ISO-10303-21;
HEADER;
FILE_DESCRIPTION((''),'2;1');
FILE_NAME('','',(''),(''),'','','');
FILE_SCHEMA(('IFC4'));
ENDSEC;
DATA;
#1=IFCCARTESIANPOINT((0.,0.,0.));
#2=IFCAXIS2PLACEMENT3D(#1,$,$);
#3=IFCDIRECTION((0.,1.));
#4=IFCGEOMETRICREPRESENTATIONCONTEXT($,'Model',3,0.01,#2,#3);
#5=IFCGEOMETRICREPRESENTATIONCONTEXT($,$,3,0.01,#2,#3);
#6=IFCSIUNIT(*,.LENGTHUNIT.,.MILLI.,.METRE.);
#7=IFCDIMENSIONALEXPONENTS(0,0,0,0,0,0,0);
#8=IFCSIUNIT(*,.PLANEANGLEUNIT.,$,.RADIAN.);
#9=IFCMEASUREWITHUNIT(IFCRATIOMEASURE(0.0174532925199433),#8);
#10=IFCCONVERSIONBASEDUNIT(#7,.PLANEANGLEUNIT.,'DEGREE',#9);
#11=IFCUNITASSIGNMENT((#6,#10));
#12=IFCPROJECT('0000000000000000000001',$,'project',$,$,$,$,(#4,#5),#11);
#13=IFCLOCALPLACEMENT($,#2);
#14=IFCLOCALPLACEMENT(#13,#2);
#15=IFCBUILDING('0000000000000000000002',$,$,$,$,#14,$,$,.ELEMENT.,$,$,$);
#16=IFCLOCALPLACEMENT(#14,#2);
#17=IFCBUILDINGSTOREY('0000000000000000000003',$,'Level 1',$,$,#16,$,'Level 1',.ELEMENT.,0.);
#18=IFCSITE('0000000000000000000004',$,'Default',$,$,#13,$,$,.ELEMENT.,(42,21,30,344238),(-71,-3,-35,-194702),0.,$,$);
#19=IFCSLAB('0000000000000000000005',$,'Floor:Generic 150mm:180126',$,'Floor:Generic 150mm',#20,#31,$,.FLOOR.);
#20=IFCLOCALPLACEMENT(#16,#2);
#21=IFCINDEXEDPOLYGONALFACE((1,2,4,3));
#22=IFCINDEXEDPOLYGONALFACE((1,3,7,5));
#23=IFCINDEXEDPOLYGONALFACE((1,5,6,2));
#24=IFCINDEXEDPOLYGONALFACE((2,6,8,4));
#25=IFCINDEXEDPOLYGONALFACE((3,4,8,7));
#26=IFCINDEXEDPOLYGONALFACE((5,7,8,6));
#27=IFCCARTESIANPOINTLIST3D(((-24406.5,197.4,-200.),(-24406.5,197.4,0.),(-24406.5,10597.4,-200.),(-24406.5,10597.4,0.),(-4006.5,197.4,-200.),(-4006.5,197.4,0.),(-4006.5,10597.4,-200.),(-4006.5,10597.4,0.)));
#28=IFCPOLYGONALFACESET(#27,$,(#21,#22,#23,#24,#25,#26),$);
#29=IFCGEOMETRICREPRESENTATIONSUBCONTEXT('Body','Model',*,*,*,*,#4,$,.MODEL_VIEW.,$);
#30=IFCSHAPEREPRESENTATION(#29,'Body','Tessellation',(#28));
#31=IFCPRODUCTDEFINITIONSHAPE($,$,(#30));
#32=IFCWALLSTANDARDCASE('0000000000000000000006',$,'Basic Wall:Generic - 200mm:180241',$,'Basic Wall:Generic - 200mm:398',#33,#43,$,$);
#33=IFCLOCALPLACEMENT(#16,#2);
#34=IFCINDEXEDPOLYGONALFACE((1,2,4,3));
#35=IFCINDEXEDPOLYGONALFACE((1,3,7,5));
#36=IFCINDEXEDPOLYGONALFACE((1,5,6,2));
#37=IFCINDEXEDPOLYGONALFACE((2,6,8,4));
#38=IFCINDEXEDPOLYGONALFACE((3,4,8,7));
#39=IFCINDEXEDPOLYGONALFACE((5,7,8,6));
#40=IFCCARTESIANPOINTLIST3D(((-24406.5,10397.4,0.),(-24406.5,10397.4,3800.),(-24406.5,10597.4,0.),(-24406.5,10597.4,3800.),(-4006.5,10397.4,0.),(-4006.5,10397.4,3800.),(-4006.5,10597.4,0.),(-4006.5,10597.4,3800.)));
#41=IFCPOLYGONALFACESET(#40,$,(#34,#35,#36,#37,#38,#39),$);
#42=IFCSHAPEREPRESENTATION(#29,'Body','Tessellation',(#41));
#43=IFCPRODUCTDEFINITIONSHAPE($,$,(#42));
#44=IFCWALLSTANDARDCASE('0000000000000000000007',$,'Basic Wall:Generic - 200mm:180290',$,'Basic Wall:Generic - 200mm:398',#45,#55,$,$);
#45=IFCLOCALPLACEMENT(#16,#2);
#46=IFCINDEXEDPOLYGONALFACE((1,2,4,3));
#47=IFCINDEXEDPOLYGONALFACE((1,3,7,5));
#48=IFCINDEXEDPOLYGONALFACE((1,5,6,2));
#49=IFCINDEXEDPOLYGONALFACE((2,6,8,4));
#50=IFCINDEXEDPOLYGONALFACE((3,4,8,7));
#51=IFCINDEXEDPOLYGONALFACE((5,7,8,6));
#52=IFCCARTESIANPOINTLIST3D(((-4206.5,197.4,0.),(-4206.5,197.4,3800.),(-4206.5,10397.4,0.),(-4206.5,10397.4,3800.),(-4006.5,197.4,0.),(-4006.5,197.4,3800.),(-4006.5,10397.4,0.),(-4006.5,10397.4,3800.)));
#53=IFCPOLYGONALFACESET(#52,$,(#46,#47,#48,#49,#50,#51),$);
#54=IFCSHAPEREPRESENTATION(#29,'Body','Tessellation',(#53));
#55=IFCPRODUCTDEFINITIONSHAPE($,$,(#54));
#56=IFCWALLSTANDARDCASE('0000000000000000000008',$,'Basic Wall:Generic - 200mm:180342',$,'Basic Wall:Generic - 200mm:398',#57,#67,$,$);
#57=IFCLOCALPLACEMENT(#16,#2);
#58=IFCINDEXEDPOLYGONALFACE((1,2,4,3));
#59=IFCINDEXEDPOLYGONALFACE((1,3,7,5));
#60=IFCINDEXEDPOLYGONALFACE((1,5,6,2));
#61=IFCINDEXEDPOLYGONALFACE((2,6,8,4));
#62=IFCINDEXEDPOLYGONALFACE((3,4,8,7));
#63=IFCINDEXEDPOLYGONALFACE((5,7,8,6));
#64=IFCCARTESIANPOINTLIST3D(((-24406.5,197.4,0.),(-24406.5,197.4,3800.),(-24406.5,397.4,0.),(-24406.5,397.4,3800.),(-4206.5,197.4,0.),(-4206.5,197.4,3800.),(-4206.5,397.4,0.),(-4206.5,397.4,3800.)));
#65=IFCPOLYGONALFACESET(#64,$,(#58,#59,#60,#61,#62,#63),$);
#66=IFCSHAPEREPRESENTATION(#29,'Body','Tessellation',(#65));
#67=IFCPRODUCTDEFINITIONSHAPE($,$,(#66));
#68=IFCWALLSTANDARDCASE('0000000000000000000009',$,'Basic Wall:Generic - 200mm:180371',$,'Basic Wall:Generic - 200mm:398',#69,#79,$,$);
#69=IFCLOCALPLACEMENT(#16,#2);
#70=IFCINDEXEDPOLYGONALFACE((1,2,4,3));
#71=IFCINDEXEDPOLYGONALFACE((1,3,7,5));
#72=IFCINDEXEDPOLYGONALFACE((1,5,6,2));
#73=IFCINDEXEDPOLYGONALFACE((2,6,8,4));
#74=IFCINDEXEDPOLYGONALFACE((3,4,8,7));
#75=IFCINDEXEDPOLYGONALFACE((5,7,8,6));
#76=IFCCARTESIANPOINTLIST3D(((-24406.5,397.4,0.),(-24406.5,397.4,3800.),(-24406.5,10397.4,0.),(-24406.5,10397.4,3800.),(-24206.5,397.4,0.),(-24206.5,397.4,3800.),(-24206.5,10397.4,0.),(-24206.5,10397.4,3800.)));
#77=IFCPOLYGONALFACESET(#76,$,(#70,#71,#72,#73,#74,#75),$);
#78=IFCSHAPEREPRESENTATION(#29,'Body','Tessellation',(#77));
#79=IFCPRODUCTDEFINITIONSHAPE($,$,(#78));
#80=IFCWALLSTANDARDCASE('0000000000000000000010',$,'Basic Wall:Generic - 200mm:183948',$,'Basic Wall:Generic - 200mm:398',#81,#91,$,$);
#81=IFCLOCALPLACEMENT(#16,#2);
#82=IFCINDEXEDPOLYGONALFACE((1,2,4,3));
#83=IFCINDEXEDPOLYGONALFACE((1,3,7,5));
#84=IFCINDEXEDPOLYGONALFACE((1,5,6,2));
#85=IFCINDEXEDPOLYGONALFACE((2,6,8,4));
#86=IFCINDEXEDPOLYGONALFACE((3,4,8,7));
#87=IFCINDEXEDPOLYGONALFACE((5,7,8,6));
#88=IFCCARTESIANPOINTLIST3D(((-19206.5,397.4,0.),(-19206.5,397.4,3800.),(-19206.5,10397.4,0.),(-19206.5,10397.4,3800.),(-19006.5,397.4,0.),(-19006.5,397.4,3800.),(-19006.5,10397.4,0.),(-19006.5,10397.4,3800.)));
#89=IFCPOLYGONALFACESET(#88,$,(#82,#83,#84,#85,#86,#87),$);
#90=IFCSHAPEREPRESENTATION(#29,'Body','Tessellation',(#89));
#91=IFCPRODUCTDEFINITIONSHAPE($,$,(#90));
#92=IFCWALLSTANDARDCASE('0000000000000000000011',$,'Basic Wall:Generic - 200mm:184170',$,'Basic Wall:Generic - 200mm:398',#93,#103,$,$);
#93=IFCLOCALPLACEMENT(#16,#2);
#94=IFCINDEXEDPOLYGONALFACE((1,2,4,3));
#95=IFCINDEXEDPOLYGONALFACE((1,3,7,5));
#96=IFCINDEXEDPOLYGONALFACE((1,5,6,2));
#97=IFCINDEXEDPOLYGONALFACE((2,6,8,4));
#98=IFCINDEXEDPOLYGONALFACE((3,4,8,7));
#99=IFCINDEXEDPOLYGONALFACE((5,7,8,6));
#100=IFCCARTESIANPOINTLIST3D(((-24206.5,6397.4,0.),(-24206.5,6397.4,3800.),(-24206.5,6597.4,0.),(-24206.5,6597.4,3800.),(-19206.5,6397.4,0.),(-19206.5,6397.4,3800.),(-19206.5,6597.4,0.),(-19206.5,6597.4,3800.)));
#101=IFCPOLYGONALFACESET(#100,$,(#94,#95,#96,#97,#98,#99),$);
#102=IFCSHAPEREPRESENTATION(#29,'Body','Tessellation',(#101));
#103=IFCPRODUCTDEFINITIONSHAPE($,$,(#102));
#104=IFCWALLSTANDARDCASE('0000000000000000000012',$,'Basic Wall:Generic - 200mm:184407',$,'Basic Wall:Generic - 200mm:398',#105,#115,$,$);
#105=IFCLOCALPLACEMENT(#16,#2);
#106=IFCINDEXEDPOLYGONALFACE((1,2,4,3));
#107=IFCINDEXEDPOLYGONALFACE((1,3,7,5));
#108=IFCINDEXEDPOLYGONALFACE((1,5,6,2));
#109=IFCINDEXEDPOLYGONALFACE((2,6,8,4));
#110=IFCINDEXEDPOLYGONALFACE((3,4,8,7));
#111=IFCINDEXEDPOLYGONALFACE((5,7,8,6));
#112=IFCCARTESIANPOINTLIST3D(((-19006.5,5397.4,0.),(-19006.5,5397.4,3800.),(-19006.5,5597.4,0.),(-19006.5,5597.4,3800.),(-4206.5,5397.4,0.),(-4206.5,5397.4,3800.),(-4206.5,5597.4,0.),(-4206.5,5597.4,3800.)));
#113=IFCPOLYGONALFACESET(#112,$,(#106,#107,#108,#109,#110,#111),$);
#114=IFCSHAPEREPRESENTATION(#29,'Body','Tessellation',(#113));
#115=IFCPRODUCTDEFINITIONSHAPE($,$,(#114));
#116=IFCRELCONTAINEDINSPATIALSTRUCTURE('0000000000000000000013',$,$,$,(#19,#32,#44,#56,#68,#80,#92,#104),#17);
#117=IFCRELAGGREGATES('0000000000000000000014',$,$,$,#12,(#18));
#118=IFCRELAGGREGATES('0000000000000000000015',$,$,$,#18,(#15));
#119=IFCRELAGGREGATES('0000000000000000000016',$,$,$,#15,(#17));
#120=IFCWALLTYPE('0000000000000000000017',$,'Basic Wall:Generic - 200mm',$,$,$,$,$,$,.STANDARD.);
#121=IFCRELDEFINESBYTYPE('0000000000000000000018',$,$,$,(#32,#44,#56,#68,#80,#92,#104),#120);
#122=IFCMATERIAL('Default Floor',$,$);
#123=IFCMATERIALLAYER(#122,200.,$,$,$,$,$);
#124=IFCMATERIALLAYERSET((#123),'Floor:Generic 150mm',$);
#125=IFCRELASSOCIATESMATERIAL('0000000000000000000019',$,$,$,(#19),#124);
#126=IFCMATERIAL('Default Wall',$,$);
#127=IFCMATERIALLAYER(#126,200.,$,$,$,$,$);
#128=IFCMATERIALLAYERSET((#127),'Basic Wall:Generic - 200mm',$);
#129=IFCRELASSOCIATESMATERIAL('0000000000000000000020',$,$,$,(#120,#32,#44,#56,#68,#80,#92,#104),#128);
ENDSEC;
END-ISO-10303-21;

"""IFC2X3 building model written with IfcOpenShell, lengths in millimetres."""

from ifc_helpers import new_model, entity, si_unit, converted_unit, direction, frame, frame_2d, origin, origin_2d_with_axis, place, context, subcontext, project, spatial, rectangle, extrude, material, layer, layer_set, layer_usage, type_object, element, save


model = new_model("IFC2X3")

# Units and contexts
model_context = context("Model", 3, precision=0.01, world=origin(), true_north=direction((0.0, 1.0)))
context_of_model = context(None, 3, precision=0.01, world=origin(), true_north=direction((0.0, 1.0)))
body_context = subcontext(model_context, "Body", "Model", "MODEL_VIEW")
ifc_project = project(units=[si_unit("LENGTHUNIT", "METRE", prefix="MILLI"), converted_unit("PLANEANGLEUNIT", "DEGREE", entity("IfcRatioMeasure", 0.0174532925199433), si_unit("PLANEANGLEUNIT", "RADIAN"), dimensions=[0, 0, 0, 0, 0, 0, 0])], contexts=[model_context, context_of_model])

# Site, building, storey
site_placement = place(None, origin())
site = spatial("IfcSite", under=ifc_project, at=site_placement, Name="Default", CompositionType="ELEMENT", RefLatitude=(42, 21, 30, 344238), RefLongitude=(-71, -3, -35, -194702), RefElevation=0.0)
building_placement = place(site_placement, origin())
building = spatial("IfcBuilding", under=site, at=building_placement, CompositionType="ELEMENT")
storey_placement = place(building_placement, origin())
storey = spatial("IfcBuildingStorey", under=building, at=storey_placement, Name="Level 1", LongName="Level 1", CompositionType="ELEMENT", Elevation=0.0)

# Slab
ifc_material_1 = material(Name="Default Floor")
ifc_layer_1 = layer(ifc_material_1, 200.0)
ifc_layer_set_1 = layer_set([ifc_layer_1], Name="Floor:Generic 150mm")
ifc_layer_usage_1 = layer_usage(ifc_layer_set_1, "AXIS3", "POSITIVE", 0.0)
slab_placement = place(storey_placement, origin())
element("IfcSlab", 1, at=slab_placement, inside=storey, material=ifc_layer_usage_1, Name="Floor:Generic 150mm:180126", ObjectType="Floor:Generic 150mm", PredefinedType="FLOOR", context=body_context, shape_type="SweptSolid", body=[
    extrude(rectangle(XDim=10400.0, YDim=20400.0, at=origin_2d_with_axis()), frame((-14206.5, 5397.4, 0.0), z_axis=(0.0, 0.0, -1.0), x_axis=(0.0, 1.0, 0.0)), (0.0, 0.0, 1.0), 200.0),
])

# Walls
ifc_material_2 = material(Name="Default Wall")
ifc_layer_2 = layer(ifc_material_2, 200.0)
ifc_layer_set_2 = layer_set([ifc_layer_2], Name="Basic Wall:Generic - 200mm")
ifc_layer_usage_2 = layer_usage(ifc_layer_set_2, "AXIS2", "NEGATIVE", 100.0)
wall_type = type_object("IfcWallType", Name="Basic Wall:Generic - 200mm", PredefinedType="STANDARD", material=ifc_layer_set_2)
wall_1_placement = place(storey_placement, frame((-24406.5, 10497.4, 0.0)))
element("IfcWallStandardCase", 2, at=wall_1_placement, inside=storey, type_object=wall_type, material=ifc_layer_usage_2, Name="Basic Wall:Generic - 200mm:180241", ObjectType="Basic Wall:Generic - 200mm:398", context=body_context, shape_type="SweptSolid", body=[
    extrude(rectangle(XDim=20400.0, YDim=200.0, at=frame_2d((10200.0, 0.0), x_axis=(-1.0, 0.0))), origin(), (0.0, 0.0, 1.0), 3800.0),
])
ifc_layer_usage_3 = layer_usage(ifc_layer_set_2, "AXIS2", "NEGATIVE", 100.0)
wall_2_placement = place(storey_placement, frame((-4106.5, 10397.4, 0.0), z_axis=(0.0, 0.0, 1.0), x_axis=(0.0, -1.0, 0.0)))
element("IfcWallStandardCase", 3, at=wall_2_placement, inside=storey, type_object=wall_type, material=ifc_layer_usage_3, Name="Basic Wall:Generic - 200mm:180290", ObjectType="Basic Wall:Generic - 200mm:398", context=body_context, shape_type="SweptSolid", body=[
    extrude(rectangle(XDim=10200.0, YDim=200.0, at=frame_2d((5100.0, 0.0), x_axis=(-1.0, 0.0))), origin(), (0.0, 0.0, 1.0), 3800.0),
])
ifc_layer_usage_4 = layer_usage(ifc_layer_set_2, "AXIS2", "NEGATIVE", 100.0)
wall_3_placement = place(storey_placement, frame((-4206.5, 297.4, 0.0), z_axis=(0.0, 0.0, 1.0), x_axis=(-1.0, 0.0, 0.0)))
element("IfcWallStandardCase", 4, at=wall_3_placement, inside=storey, type_object=wall_type, material=ifc_layer_usage_4, Name="Basic Wall:Generic - 200mm:180342", ObjectType="Basic Wall:Generic - 200mm:398", context=body_context, shape_type="SweptSolid", body=[
    extrude(rectangle(XDim=20200.0, YDim=200.0, at=frame_2d((10100.0, 0.0), x_axis=(-1.0, 0.0))), origin(), (0.0, 0.0, 1.0), 3800.0),
])
ifc_layer_usage_5 = layer_usage(ifc_layer_set_2, "AXIS2", "NEGATIVE", 100.0)
wall_4_placement = place(storey_placement, frame((-24306.5, 397.4, 0.0), z_axis=(0.0, 0.0, 1.0), x_axis=(0.0, 1.0, 0.0)))
element("IfcWallStandardCase", 5, at=wall_4_placement, inside=storey, type_object=wall_type, material=ifc_layer_usage_5, Name="Basic Wall:Generic - 200mm:180371", ObjectType="Basic Wall:Generic - 200mm:398", context=body_context, shape_type="SweptSolid", body=[
    extrude(rectangle(XDim=10000.0, YDim=200.0, at=frame_2d((5000.0, 0.0), x_axis=(-1.0, 0.0))), origin(), (0.0, 0.0, 1.0), 3800.0),
])
ifc_layer_usage_6 = layer_usage(ifc_layer_set_2, "AXIS2", "NEGATIVE", 100.0)
wall_5_placement = place(storey_placement, frame((-19106.5, 10397.4, 0.0), z_axis=(0.0, 0.0, 1.0), x_axis=(0.0, -1.0, 0.0)))
element("IfcWallStandardCase", 6, at=wall_5_placement, inside=storey, type_object=wall_type, material=ifc_layer_usage_6, Name="Basic Wall:Generic - 200mm:183948", ObjectType="Basic Wall:Generic - 200mm:398", context=body_context, shape_type="SweptSolid", body=[
    extrude(rectangle(XDim=10000.0, YDim=200.0, at=frame_2d((5000.0, 0.0), x_axis=(-1.0, 0.0))), origin(), (0.0, 0.0, 1.0), 3800.0),
])
ifc_layer_usage_7 = layer_usage(ifc_layer_set_2, "AXIS2", "NEGATIVE", 100.0)
wall_6_placement = place(storey_placement, frame((-24206.5, 6497.4, 0.0)))
element("IfcWallStandardCase", 7, at=wall_6_placement, inside=storey, type_object=wall_type, material=ifc_layer_usage_7, Name="Basic Wall:Generic - 200mm:184170", ObjectType="Basic Wall:Generic - 200mm:398", context=body_context, shape_type="SweptSolid", body=[
    extrude(rectangle(XDim=5000.0, YDim=200.0, at=frame_2d((2500.0, 0.0), x_axis=(-1.0, 0.0))), origin(), (0.0, 0.0, 1.0), 3800.0),
])
ifc_layer_usage_8 = layer_usage(ifc_layer_set_2, "AXIS2", "NEGATIVE", 100.0)
wall_7_placement = place(storey_placement, frame((-4206.5, 5497.4, 0.0), z_axis=(0.0, 0.0, 1.0), x_axis=(-1.0, 0.0, 0.0)))
element("IfcWallStandardCase", 8, at=wall_7_placement, inside=storey, type_object=wall_type, material=ifc_layer_usage_8, Name="Basic Wall:Generic - 200mm:184407", ObjectType="Basic Wall:Generic - 200mm:398", context=body_context, shape_type="SweptSolid", body=[
    extrude(rectangle(XDim=14800.0, YDim=200.0, at=frame_2d((7400.0, 0.0), x_axis=(-1.0, 0.0))), origin(), (0.0, 0.0, 1.0), 3800.0),
])

save(model, "model.ifc")
